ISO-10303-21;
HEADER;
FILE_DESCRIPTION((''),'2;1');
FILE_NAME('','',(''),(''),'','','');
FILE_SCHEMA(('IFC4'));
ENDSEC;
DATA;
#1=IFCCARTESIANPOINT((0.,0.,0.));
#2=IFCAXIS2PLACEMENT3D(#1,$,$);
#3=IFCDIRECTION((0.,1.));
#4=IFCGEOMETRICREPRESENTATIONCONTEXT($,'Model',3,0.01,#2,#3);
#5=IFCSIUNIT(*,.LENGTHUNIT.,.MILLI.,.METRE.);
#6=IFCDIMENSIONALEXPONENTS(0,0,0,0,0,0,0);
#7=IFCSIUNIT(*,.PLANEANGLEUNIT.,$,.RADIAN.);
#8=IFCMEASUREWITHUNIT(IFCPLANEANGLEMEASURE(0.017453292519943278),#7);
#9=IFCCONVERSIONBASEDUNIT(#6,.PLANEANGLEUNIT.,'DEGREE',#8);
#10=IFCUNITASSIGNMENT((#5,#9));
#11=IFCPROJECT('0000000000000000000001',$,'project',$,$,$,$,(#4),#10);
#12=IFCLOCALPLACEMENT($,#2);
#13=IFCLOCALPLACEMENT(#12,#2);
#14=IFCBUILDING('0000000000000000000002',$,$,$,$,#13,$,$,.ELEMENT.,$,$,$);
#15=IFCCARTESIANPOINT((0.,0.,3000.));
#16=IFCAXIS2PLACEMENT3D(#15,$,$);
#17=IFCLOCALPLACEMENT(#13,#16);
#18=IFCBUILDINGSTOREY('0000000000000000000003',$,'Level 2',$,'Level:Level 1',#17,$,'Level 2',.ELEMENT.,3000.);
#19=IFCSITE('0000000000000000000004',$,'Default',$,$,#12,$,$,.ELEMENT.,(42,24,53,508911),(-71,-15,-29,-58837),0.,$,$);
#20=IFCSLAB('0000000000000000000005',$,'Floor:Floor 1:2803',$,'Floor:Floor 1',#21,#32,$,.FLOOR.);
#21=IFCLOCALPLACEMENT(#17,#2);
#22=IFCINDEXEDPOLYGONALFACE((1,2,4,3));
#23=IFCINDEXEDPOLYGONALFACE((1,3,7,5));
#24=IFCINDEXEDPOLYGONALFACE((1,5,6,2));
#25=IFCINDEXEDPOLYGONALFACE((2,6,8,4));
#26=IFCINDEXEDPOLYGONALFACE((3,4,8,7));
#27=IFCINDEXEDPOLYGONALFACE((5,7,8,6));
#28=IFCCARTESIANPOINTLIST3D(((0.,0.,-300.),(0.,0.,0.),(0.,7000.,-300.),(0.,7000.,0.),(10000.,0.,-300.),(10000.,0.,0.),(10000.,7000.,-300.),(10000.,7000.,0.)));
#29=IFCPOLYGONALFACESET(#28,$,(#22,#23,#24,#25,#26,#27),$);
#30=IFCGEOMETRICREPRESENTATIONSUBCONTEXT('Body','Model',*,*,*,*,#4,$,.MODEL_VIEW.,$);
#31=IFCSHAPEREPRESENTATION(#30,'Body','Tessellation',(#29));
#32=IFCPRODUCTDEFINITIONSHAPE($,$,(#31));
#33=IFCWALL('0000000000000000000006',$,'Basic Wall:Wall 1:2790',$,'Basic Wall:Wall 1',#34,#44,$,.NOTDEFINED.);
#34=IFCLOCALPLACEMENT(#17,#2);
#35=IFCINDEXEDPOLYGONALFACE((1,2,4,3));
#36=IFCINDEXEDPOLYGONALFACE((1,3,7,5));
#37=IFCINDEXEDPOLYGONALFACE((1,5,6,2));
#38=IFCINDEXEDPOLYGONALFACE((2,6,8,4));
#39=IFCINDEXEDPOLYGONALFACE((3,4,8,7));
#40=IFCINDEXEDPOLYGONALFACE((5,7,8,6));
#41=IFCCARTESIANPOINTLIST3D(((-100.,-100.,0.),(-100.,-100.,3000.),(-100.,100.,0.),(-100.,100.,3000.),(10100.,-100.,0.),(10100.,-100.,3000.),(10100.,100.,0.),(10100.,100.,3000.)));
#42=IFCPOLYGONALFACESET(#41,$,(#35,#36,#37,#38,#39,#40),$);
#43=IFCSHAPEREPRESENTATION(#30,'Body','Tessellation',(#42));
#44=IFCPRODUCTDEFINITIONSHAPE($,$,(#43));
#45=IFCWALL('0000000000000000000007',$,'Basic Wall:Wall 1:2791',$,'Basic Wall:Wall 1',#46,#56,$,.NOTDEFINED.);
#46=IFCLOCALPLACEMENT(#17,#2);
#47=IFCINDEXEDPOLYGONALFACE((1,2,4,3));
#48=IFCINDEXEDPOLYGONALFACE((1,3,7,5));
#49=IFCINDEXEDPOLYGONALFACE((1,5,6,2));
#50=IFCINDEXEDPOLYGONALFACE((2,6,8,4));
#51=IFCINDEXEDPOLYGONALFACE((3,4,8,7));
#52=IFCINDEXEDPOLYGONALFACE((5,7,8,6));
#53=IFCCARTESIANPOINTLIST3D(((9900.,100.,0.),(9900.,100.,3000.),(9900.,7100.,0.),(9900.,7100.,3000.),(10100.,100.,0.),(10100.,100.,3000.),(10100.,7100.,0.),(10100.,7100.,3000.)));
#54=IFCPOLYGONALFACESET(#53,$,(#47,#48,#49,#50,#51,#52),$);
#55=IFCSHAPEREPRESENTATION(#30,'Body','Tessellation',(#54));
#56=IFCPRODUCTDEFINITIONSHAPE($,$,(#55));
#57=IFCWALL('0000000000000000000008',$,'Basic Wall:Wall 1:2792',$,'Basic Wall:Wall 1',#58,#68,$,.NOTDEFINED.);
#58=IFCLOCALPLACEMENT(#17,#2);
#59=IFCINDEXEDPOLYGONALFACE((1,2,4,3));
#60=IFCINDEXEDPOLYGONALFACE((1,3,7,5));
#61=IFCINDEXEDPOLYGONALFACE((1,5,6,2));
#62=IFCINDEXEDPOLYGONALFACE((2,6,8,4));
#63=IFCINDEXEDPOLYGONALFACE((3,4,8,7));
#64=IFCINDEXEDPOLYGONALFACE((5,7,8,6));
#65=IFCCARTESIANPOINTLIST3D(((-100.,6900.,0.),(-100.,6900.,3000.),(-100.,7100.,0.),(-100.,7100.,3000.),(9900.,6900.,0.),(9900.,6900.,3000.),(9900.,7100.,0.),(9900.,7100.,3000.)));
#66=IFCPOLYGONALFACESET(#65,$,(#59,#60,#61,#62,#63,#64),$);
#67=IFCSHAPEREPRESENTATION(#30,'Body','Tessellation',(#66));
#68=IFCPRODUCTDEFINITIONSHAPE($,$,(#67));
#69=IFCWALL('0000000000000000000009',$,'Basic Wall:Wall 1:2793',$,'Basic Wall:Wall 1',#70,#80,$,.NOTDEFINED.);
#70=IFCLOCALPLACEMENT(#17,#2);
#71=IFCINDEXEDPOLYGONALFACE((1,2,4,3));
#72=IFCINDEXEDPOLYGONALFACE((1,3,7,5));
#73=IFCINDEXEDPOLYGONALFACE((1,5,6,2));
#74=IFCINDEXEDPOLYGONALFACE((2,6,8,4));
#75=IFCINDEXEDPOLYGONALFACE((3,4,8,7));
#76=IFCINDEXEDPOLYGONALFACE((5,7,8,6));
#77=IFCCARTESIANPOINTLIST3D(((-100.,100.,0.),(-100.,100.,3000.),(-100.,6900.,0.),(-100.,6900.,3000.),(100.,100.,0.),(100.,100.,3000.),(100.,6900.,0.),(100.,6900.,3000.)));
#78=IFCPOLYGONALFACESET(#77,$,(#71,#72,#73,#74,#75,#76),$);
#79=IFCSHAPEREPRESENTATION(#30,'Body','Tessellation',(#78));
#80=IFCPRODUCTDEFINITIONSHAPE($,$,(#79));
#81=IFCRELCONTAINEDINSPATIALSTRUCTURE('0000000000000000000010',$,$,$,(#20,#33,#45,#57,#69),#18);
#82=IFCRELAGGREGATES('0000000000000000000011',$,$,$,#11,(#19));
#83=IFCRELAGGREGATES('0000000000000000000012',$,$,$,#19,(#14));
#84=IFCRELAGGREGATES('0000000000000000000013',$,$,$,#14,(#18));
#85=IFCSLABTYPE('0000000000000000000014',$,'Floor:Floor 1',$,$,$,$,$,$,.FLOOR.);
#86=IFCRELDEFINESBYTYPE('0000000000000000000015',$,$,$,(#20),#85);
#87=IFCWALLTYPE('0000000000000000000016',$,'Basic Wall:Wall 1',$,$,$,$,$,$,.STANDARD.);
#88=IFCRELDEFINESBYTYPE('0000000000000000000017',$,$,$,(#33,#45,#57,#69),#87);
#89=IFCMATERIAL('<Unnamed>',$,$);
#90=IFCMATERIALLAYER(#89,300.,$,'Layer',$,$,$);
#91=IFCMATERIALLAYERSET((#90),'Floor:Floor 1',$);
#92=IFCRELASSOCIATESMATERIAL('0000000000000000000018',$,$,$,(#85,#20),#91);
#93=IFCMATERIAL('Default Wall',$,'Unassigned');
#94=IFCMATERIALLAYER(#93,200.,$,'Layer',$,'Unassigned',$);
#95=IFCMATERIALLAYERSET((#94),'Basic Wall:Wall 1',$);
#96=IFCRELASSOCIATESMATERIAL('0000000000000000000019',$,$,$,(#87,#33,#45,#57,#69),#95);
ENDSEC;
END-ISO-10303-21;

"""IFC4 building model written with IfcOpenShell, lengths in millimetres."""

from ifc_helpers import new_model, entity, si_unit, converted_unit, direction, frame, frame_2d, origin, origin_2d_with_axis, place, context, subcontext, project, spatial, rectangle, extrude, material, layer, layer_set, layer_usage, type_object, element, save


model = new_model("IFC4")

# Units and contexts
model_context = context("Model", 3, precision=0.01, world=origin(), true_north=direction((0.0, 1.0)))
body_context = subcontext(model_context, "Body", "Model", "MODEL_VIEW")
ifc_project = project(units=[si_unit("LENGTHUNIT", "METRE", prefix="MILLI"), converted_unit("PLANEANGLEUNIT", "DEGREE", entity("IfcPlaneAngleMeasure", 0.017453292519943278), si_unit("PLANEANGLEUNIT", "RADIAN"), dimensions=[0, 0, 0, 0, 0, 0, 0])], contexts=[model_context])

# Site, building, storey
site_placement = place(None, origin())
site = spatial("IfcSite", under=ifc_project, at=site_placement, Name="Default", CompositionType="ELEMENT", RefLatitude=(42, 24, 53, 508911), RefLongitude=(-71, -15, -29, -58837), RefElevation=0.0)
building_placement = place(site_placement, origin())
building = spatial("IfcBuilding", under=site, at=building_placement, CompositionType="ELEMENT")
storey_placement = place(building_placement, frame((0.0, 0.0, 3000.0)))
storey = spatial("IfcBuildingStorey", under=building, at=storey_placement, Name="Level 2", ObjectType="Level:Level 1", LongName="Level 2", CompositionType="ELEMENT", Elevation=3000.0)

# Slab
ifc_material_1 = material(Name="<Unnamed>")
ifc_layer_1 = layer(ifc_material_1, 300.0, Name="Layer")
ifc_layer_set_1 = layer_set([ifc_layer_1], Name="Floor:Floor 1")
ifc_layer_usage_1 = layer_usage(ifc_layer_set_1, "AXIS3", "POSITIVE", 0.0)
slab_type = type_object("IfcSlabType", Name="Floor:Floor 1", PredefinedType="FLOOR", material=ifc_layer_set_1)
slab_placement = place(storey_placement, origin())
element("IfcSlab", 1, at=slab_placement, inside=storey, type_object=slab_type, material=ifc_layer_usage_1, Name="Floor:Floor 1:2803", ObjectType="Floor:Floor 1", PredefinedType="FLOOR", context=body_context, shape_type="SweptSolid", body=[
    extrude(rectangle(XDim=7000.0, YDim=10000.0, at=origin_2d_with_axis()), frame((5000.0, 3500.0, 0.0), z_axis=(0.0, 0.0, -1.0), x_axis=(0.0, 1.0, 0.0)), (0.0, 0.0, 1.0), 300.0),
])

# Walls
ifc_material_2 = material(Name="Default Wall", Category="Unassigned")
ifc_layer_2 = layer(ifc_material_2, 200.0, Name="Layer", Category="Unassigned")
ifc_layer_set_2 = layer_set([ifc_layer_2], Name="Basic Wall:Wall 1")
ifc_layer_usage_2 = layer_usage(ifc_layer_set_2, "AXIS2", "NEGATIVE", 100.0)
wall_type = type_object("IfcWallType", Name="Basic Wall:Wall 1", PredefinedType="STANDARD", material=ifc_layer_set_2)
wall_1_placement = place(storey_placement, frame((-100.0, 0.0, 0.0)))
element("IfcWall", 2, at=wall_1_placement, inside=storey, type_object=wall_type, material=ifc_layer_usage_2, Name="Basic Wall:Wall 1:2790", ObjectType="Basic Wall:Wall 1", PredefinedType="NOTDEFINED", context=body_context, shape_type="SweptSolid", body=[
    extrude(rectangle(XDim=10200.0, YDim=200.0, at=frame_2d((5100.0, 0.0), x_axis=(-1.0, 0.0))), origin(), (0.0, 0.0, 1.0), 3000.0),
])
ifc_layer_usage_3 = layer_usage(ifc_layer_set_2, "AXIS2", "NEGATIVE", 100.0)
wall_2_placement = place(storey_placement, frame((10000.0, 100.0, 0.0), z_axis=(0.0, 0.0, 1.0), x_axis=(0.0, 1.0, 0.0)))
element("IfcWall", 3, at=wall_2_placement, inside=storey, type_object=wall_type, material=ifc_layer_usage_3, Name="Basic Wall:Wall 1:2791", ObjectType="Basic Wall:Wall 1", PredefinedType="NOTDEFINED", context=body_context, shape_type="SweptSolid", body=[
    extrude(rectangle(XDim=7000.0, YDim=200.0, at=frame_2d((3500.0, 0.0), x_axis=(-1.0, 0.0))), origin(), (0.0, 0.0, 1.0), 3000.0),
])
ifc_layer_usage_4 = layer_usage(ifc_layer_set_2, "AXIS2", "NEGATIVE", 100.0)
wall_3_placement = place(storey_placement, frame((9900.0, 7000.0, 0.0), z_axis=(0.0, 0.0, 1.0), x_axis=(-1.0, 0.0, 0.0)))
element("IfcWall", 4, at=wall_3_placement, inside=storey, type_object=wall_type, material=ifc_layer_usage_4, Name="Basic Wall:Wall 1:2792", ObjectType="Basic Wall:Wall 1", PredefinedType="NOTDEFINED", context=body_context, shape_type="SweptSolid", body=[
    extrude(rectangle(XDim=10000.0, YDim=200.0, at=frame_2d((5000.0, 0.0), x_axis=(-1.0, 0.0))), origin(), (0.0, 0.0, 1.0), 3000.0),
])
ifc_layer_usage_5 = layer_usage(ifc_layer_set_2, "AXIS2", "NEGATIVE", 100.0)
wall_4_placement = place(storey_placement, frame((0.0, 6900.0, 0.0), z_axis=(0.0, 0.0, 1.0), x_axis=(0.0, -1.0, 0.0)))
element("IfcWall", 5, at=wall_4_placement, inside=storey, type_object=wall_type, material=ifc_layer_usage_5, Name="Basic Wall:Wall 1:2793", ObjectType="Basic Wall:Wall 1", PredefinedType="NOTDEFINED", context=body_context, shape_type="SweptSolid", body=[
    extrude(rectangle(XDim=6800.0, YDim=200.0, at=frame_2d((3400.0, 0.0), x_axis=(-1.0, 0.0))), origin(), (0.0, 0.0, 1.0), 3000.0),
])

save(model, "model.ifc")
